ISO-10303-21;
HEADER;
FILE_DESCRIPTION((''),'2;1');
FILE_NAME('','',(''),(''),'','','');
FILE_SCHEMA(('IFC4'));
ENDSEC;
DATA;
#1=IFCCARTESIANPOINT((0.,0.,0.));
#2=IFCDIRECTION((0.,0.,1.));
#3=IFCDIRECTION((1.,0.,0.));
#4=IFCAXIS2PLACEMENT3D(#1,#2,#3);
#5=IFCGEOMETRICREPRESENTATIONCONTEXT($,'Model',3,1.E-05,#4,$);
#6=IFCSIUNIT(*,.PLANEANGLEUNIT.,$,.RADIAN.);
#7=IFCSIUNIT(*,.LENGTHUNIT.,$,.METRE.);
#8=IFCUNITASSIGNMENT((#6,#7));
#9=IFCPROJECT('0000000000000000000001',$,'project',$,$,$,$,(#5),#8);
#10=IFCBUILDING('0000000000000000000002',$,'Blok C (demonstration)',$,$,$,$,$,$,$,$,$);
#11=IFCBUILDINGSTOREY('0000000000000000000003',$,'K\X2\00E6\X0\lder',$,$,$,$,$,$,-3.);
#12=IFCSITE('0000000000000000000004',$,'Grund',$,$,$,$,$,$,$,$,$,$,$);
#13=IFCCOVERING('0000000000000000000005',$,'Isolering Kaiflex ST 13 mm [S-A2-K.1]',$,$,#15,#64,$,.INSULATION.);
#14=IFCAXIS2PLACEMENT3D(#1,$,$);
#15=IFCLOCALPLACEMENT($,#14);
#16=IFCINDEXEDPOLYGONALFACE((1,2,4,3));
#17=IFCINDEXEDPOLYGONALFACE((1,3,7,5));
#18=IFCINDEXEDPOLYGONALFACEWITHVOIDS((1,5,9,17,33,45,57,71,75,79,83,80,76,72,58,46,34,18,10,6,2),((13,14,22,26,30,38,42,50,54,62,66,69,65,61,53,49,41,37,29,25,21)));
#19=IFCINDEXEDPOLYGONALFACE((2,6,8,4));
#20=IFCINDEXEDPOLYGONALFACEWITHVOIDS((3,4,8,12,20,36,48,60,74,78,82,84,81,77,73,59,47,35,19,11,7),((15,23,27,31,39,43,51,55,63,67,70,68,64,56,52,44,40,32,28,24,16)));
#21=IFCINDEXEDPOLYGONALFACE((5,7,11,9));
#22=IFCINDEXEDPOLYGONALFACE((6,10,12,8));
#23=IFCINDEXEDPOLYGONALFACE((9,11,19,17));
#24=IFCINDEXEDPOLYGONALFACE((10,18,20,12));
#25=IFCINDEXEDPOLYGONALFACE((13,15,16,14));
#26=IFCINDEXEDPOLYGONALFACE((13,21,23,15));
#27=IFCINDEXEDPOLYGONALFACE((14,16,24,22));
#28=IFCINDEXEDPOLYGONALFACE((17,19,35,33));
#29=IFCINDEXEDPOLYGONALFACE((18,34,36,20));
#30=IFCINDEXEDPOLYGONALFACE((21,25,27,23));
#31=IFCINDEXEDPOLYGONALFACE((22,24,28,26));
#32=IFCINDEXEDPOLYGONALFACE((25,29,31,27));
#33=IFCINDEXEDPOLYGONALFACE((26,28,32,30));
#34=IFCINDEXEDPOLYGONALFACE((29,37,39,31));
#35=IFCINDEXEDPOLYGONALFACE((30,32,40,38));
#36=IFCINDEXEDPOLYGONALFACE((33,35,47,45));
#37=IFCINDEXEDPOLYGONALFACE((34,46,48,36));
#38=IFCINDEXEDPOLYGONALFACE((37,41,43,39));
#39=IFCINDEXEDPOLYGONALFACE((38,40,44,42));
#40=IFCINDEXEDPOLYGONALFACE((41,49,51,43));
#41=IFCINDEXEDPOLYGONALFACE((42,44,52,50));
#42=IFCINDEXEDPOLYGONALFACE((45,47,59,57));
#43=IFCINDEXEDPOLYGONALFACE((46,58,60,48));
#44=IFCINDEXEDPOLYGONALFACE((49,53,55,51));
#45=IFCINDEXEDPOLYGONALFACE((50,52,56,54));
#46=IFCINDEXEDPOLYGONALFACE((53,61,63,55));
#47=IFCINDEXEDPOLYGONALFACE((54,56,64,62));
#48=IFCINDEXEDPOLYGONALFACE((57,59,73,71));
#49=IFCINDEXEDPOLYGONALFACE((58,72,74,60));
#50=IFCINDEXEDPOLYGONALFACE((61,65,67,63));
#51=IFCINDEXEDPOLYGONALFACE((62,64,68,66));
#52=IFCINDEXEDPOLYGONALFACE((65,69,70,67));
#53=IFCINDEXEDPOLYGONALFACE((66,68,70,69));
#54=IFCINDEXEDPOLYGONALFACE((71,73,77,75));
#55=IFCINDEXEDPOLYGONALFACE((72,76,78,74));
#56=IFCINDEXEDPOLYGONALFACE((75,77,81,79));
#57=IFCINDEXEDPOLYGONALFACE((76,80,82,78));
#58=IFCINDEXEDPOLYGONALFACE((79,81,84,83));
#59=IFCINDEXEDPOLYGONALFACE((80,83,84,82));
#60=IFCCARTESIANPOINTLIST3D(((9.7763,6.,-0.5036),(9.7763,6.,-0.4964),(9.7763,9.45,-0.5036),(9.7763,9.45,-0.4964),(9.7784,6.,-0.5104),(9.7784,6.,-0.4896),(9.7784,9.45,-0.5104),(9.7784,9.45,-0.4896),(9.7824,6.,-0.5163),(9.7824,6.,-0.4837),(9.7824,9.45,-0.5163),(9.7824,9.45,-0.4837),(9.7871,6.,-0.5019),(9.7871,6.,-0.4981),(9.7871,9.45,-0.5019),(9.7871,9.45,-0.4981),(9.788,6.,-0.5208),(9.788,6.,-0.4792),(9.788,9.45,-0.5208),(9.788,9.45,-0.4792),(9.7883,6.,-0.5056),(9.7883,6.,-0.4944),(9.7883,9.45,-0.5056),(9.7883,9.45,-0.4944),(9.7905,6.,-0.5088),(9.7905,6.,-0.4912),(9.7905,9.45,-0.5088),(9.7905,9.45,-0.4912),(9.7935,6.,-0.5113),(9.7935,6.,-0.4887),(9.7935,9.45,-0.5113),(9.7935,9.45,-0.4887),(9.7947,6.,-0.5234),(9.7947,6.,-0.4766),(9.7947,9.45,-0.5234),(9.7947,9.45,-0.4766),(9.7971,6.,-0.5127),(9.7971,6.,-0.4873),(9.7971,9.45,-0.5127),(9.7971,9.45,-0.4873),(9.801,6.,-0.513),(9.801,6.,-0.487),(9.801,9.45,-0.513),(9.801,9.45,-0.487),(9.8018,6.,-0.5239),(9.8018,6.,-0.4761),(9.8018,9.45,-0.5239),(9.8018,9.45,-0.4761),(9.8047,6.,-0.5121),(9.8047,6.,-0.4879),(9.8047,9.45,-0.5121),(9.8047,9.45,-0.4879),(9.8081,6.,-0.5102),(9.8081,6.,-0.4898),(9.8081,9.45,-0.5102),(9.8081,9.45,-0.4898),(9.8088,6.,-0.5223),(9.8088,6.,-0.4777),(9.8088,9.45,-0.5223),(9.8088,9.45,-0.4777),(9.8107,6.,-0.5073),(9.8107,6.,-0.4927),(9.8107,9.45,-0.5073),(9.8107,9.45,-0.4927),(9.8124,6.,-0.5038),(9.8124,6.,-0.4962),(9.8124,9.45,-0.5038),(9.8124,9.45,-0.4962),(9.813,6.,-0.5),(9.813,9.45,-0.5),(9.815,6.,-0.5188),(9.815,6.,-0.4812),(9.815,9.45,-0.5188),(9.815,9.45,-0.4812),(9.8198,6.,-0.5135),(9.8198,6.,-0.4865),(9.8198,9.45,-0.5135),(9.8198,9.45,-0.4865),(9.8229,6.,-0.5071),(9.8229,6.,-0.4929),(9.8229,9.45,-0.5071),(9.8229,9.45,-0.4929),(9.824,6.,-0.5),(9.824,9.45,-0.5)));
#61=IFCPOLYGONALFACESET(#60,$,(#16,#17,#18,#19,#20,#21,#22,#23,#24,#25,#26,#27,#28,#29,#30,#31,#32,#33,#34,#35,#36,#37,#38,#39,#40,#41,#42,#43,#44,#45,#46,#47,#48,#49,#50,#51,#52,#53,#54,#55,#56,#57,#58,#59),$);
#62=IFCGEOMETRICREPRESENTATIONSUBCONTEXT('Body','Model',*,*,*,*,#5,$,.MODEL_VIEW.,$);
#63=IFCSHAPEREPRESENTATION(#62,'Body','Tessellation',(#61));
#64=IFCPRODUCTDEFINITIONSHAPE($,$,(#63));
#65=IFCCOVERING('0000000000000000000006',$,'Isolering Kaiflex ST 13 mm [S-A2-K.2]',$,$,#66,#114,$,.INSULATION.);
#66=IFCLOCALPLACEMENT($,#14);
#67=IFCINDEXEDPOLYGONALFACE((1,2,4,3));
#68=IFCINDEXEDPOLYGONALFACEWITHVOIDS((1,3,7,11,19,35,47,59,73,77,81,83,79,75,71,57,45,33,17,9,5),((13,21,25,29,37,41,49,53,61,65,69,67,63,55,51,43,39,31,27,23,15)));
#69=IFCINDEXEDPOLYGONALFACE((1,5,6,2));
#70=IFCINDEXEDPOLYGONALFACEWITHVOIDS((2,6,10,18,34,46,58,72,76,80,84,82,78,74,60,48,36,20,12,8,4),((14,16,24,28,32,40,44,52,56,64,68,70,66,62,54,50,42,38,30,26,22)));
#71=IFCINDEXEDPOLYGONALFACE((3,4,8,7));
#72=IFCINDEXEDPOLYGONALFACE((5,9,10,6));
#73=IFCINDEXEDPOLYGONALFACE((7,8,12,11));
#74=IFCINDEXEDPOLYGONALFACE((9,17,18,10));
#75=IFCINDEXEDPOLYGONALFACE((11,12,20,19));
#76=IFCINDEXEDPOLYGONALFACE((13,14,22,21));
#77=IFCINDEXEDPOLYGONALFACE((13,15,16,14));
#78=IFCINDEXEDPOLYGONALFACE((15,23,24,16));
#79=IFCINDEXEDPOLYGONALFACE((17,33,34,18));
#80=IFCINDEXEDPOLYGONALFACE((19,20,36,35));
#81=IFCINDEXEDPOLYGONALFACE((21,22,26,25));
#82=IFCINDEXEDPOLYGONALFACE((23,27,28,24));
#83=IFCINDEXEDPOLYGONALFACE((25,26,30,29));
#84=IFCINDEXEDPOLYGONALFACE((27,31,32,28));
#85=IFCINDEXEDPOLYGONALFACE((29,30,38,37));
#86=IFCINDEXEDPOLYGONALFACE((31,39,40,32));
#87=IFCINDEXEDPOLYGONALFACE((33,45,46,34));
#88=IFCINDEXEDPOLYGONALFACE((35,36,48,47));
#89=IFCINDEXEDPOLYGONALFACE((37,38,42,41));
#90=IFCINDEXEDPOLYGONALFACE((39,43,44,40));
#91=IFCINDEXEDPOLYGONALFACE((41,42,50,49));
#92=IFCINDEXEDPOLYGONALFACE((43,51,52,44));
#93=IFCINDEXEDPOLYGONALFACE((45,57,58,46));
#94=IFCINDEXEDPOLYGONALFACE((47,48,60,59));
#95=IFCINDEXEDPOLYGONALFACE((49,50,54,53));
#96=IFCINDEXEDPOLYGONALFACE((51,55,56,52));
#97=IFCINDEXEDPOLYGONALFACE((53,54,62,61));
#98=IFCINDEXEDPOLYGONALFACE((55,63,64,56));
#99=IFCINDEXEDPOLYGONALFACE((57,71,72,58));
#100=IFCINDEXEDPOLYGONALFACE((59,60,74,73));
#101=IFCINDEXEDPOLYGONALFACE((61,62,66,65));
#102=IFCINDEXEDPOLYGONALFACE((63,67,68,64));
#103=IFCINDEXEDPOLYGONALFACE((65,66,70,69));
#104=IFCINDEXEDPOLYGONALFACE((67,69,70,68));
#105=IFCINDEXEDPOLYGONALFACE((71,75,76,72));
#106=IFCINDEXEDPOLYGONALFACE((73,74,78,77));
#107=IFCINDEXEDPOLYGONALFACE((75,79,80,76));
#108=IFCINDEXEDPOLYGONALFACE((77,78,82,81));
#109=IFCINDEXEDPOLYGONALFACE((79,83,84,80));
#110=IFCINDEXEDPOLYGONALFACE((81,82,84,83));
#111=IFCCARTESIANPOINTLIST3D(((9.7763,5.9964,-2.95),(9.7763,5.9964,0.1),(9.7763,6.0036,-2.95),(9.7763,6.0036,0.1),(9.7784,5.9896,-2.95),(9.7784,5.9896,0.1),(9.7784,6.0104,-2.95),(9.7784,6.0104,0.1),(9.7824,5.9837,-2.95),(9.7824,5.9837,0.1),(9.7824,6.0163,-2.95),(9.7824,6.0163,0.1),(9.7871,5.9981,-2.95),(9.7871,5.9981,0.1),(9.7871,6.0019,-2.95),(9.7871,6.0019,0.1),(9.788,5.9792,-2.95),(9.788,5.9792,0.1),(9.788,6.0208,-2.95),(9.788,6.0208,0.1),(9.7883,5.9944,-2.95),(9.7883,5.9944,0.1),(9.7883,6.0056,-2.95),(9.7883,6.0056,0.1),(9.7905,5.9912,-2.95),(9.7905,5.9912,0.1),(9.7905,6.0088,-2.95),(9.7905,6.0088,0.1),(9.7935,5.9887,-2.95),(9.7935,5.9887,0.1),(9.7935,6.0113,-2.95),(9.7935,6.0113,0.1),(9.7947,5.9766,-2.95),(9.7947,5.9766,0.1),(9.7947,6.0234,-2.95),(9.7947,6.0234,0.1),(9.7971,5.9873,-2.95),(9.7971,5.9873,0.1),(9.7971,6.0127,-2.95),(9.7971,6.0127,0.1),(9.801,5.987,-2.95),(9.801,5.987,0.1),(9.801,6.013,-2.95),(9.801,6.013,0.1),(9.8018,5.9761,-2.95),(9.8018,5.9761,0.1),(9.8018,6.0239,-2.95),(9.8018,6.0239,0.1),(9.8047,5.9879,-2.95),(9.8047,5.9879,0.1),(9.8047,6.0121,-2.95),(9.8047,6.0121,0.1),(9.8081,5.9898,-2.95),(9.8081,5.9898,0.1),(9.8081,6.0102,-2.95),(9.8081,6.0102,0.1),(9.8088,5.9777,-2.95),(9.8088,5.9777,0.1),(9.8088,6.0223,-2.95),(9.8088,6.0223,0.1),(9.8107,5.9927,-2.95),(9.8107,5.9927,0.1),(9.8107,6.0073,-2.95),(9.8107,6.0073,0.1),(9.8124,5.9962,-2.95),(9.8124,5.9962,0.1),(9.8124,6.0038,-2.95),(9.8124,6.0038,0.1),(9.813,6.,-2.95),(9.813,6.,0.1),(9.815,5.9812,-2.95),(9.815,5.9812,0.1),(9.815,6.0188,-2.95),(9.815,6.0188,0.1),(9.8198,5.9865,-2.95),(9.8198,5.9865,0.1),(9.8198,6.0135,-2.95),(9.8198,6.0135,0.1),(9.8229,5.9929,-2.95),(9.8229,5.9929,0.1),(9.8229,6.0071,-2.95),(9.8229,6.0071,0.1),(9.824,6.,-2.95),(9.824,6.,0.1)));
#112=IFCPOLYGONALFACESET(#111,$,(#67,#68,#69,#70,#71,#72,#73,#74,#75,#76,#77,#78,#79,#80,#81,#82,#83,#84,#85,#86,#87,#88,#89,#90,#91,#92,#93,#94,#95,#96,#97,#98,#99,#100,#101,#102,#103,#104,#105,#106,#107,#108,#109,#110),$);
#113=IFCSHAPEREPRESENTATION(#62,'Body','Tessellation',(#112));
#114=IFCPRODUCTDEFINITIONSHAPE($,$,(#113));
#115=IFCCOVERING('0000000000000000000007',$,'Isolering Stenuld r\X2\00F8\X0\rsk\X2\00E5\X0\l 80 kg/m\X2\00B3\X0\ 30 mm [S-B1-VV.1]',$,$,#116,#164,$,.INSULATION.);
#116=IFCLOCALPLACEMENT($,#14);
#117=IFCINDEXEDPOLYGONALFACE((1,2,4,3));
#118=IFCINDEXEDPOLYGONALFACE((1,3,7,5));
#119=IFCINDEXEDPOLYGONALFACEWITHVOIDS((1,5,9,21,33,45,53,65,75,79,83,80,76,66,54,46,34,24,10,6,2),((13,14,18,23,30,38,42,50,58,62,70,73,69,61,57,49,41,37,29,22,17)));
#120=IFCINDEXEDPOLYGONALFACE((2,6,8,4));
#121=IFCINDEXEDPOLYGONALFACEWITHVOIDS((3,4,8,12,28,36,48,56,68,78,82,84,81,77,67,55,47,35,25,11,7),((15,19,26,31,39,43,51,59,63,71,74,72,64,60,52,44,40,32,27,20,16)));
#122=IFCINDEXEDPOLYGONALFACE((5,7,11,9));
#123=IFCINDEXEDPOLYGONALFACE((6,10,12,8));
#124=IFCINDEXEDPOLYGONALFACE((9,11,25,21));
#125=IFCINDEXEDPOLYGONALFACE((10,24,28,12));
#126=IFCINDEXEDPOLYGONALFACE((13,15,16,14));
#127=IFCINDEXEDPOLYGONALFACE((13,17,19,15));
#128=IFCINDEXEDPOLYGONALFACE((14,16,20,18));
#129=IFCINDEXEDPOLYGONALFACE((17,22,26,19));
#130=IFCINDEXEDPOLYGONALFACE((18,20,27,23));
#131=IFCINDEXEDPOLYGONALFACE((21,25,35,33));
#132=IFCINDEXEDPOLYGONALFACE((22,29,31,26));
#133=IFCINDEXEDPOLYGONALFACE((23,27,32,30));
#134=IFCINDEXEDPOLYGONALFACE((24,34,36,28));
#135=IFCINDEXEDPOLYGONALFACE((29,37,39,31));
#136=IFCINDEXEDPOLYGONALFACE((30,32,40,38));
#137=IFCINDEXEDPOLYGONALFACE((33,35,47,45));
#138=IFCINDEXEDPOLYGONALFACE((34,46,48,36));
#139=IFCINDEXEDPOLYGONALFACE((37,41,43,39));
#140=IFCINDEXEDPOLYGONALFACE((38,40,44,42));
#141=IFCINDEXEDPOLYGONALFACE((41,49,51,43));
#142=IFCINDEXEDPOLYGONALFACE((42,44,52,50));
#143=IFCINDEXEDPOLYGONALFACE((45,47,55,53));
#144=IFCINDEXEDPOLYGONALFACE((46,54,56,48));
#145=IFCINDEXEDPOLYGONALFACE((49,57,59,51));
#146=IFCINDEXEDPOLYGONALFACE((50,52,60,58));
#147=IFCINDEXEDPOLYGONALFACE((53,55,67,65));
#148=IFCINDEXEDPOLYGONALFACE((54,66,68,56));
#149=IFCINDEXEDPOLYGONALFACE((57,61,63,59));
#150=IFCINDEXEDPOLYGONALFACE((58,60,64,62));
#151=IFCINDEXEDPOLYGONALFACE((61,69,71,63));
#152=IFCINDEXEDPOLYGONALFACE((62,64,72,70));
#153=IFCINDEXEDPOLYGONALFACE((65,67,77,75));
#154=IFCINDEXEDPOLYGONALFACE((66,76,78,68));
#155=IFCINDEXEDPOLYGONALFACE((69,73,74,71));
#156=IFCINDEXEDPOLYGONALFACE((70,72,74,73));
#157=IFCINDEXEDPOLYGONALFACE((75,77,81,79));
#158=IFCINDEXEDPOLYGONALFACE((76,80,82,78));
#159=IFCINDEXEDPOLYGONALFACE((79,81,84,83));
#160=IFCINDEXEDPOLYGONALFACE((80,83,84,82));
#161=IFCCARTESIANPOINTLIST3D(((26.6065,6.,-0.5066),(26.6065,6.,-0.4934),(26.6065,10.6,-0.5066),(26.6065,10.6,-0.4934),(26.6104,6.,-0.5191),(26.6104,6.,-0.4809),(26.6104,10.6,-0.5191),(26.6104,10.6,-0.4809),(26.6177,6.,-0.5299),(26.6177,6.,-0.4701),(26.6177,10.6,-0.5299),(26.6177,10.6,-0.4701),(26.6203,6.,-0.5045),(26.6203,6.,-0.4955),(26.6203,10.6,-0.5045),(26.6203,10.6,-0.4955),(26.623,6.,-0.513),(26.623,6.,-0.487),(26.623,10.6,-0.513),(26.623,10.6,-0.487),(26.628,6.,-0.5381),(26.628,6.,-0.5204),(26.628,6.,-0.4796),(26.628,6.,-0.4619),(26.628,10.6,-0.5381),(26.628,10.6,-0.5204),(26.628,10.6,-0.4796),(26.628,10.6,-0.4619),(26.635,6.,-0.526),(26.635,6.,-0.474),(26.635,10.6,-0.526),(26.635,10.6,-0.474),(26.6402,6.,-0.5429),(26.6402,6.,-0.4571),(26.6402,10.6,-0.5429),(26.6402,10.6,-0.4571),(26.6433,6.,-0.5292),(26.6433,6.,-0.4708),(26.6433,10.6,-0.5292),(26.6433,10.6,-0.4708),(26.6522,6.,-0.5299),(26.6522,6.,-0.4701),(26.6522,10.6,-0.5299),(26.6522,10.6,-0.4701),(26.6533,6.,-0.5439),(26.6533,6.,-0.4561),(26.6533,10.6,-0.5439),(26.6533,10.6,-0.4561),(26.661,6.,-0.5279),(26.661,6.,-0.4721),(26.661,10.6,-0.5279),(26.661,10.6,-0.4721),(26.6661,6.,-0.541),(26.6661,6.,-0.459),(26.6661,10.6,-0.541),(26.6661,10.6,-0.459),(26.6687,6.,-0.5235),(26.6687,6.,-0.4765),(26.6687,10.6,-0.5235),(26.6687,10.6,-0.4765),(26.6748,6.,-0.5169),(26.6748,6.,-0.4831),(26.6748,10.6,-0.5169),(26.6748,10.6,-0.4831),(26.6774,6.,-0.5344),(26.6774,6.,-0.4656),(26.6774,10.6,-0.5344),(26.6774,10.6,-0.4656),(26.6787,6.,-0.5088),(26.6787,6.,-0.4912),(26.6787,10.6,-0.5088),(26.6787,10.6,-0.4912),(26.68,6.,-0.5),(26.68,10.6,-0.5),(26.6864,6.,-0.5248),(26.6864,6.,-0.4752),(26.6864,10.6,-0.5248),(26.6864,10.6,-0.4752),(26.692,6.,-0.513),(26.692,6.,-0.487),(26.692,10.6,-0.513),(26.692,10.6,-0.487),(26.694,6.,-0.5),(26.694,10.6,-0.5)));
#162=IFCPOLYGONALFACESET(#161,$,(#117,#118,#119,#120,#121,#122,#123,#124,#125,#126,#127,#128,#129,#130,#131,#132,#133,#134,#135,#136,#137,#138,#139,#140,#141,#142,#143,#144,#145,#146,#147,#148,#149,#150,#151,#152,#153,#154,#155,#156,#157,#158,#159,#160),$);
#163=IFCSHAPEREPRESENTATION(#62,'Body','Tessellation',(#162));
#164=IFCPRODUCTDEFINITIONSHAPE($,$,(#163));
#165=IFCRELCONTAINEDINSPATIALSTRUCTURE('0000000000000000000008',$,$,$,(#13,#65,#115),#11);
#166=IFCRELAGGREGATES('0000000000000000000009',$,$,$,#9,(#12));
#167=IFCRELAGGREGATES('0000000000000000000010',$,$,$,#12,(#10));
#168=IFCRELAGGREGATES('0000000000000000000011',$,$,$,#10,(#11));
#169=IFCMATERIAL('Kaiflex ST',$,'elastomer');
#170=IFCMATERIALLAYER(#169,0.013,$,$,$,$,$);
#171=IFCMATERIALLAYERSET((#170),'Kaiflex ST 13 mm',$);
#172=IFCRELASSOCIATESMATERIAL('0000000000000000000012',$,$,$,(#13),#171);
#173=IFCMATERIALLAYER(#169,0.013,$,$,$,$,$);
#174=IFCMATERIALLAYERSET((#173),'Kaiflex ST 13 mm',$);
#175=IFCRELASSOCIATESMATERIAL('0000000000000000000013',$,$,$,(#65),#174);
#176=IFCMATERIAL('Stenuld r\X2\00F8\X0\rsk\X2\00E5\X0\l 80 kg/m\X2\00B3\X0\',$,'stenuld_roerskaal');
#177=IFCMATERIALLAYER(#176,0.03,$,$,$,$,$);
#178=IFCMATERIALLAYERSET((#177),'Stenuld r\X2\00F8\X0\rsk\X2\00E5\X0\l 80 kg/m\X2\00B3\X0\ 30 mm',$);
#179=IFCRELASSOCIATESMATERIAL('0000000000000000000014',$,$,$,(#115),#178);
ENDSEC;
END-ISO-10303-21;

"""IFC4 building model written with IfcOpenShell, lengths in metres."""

from ifc_helpers import new_model, si_unit, frame, origin_with_axes, place, context, subcontext, project, spatial, hollow_circle, extrude, material, layer, layer_set, element, save


model = new_model("IFC4")

# Units and contexts
model_context = context("Model", 3, precision=1e-05, world=origin_with_axes())
body_context = subcontext(model_context, "Body", "Model", "MODEL_VIEW")
ifc_project = project(units=[si_unit("PLANEANGLEUNIT", "RADIAN"), si_unit("LENGTHUNIT", "METRE")], contexts=[model_context])

# Site, building, storey
site = spatial("IfcSite", under=ifc_project, Name="Grund")
building = spatial("IfcBuilding", under=site, Name="Blok C (demonstration)")
storey = spatial("IfcBuildingStorey", under=building, Name="Kælder", Elevation=-3.0)

# Coverings
ifc_material_1 = material(Name="Stenuld rørskål 80 kg/m³", Category="stenuld_roerskaal")
ifc_material_2 = material(Name="Kaiflex ST", Category="elastomer")
ifc_layer_1 = layer(ifc_material_2, 0.013)
ifc_layer_set_1 = layer_set([ifc_layer_1], Name="Kaiflex ST 13 mm")
covering_1_placement = place(None, origin_with_axes())
element("IfcCovering", 1, at=covering_1_placement, inside=storey, material=ifc_layer_set_1, Name="Isolering Kaiflex ST 13 mm [S-A2-K.1]", PredefinedType="INSULATION", context=body_context, shape_type="SweptSolid", body=[
    extrude(hollow_circle(Radius=0.024, WallThickness=0.011), frame((9.8, 9.45, -0.5), z_axis=(0.0, -1.0, 0.0), x_axis=(1.0, 0.0, 0.0)), (0.0, 0.0, 1.0), 3.45),
])
ifc_layer_2 = layer(ifc_material_2, 0.013)
ifc_layer_set_2 = layer_set([ifc_layer_2], Name="Kaiflex ST 13 mm")
covering_2_placement = place(None, origin_with_axes())
element("IfcCovering", 2, at=covering_2_placement, inside=storey, material=ifc_layer_set_2, Name="Isolering Kaiflex ST 13 mm [S-A2-K.2]", PredefinedType="INSULATION", context=body_context, shape_type="SweptSolid", body=[
    extrude(hollow_circle(Radius=0.024, WallThickness=0.011), frame((9.8, 6.0, -2.95), z_axis=(0.0, 0.0, 1.0), x_axis=(1.0, 0.0, 0.0)), (0.0, 0.0, 1.0), 3.05),
])
ifc_layer_3 = layer(ifc_material_1, 0.03)
ifc_layer_set_3 = layer_set([ifc_layer_3], Name="Stenuld rørskål 80 kg/m³ 30 mm")
covering_3_placement = place(None, origin_with_axes())
element("IfcCovering", 3, at=covering_3_placement, inside=storey, material=ifc_layer_set_3, Name="Isolering Stenuld rørskål 80 kg/m³ 30 mm [S-B1-VV.1]", PredefinedType="INSULATION", context=body_context, shape_type="SweptSolid", body=[
    extrude(hollow_circle(Radius=0.044, WallThickness=0.014), frame((26.65, 10.6, -0.5), z_axis=(0.0, -1.0, 0.0), x_axis=(1.0, 0.0, 0.0)), (0.0, 0.0, 1.0), 4.6),
])

save(model, "model.ifc")
